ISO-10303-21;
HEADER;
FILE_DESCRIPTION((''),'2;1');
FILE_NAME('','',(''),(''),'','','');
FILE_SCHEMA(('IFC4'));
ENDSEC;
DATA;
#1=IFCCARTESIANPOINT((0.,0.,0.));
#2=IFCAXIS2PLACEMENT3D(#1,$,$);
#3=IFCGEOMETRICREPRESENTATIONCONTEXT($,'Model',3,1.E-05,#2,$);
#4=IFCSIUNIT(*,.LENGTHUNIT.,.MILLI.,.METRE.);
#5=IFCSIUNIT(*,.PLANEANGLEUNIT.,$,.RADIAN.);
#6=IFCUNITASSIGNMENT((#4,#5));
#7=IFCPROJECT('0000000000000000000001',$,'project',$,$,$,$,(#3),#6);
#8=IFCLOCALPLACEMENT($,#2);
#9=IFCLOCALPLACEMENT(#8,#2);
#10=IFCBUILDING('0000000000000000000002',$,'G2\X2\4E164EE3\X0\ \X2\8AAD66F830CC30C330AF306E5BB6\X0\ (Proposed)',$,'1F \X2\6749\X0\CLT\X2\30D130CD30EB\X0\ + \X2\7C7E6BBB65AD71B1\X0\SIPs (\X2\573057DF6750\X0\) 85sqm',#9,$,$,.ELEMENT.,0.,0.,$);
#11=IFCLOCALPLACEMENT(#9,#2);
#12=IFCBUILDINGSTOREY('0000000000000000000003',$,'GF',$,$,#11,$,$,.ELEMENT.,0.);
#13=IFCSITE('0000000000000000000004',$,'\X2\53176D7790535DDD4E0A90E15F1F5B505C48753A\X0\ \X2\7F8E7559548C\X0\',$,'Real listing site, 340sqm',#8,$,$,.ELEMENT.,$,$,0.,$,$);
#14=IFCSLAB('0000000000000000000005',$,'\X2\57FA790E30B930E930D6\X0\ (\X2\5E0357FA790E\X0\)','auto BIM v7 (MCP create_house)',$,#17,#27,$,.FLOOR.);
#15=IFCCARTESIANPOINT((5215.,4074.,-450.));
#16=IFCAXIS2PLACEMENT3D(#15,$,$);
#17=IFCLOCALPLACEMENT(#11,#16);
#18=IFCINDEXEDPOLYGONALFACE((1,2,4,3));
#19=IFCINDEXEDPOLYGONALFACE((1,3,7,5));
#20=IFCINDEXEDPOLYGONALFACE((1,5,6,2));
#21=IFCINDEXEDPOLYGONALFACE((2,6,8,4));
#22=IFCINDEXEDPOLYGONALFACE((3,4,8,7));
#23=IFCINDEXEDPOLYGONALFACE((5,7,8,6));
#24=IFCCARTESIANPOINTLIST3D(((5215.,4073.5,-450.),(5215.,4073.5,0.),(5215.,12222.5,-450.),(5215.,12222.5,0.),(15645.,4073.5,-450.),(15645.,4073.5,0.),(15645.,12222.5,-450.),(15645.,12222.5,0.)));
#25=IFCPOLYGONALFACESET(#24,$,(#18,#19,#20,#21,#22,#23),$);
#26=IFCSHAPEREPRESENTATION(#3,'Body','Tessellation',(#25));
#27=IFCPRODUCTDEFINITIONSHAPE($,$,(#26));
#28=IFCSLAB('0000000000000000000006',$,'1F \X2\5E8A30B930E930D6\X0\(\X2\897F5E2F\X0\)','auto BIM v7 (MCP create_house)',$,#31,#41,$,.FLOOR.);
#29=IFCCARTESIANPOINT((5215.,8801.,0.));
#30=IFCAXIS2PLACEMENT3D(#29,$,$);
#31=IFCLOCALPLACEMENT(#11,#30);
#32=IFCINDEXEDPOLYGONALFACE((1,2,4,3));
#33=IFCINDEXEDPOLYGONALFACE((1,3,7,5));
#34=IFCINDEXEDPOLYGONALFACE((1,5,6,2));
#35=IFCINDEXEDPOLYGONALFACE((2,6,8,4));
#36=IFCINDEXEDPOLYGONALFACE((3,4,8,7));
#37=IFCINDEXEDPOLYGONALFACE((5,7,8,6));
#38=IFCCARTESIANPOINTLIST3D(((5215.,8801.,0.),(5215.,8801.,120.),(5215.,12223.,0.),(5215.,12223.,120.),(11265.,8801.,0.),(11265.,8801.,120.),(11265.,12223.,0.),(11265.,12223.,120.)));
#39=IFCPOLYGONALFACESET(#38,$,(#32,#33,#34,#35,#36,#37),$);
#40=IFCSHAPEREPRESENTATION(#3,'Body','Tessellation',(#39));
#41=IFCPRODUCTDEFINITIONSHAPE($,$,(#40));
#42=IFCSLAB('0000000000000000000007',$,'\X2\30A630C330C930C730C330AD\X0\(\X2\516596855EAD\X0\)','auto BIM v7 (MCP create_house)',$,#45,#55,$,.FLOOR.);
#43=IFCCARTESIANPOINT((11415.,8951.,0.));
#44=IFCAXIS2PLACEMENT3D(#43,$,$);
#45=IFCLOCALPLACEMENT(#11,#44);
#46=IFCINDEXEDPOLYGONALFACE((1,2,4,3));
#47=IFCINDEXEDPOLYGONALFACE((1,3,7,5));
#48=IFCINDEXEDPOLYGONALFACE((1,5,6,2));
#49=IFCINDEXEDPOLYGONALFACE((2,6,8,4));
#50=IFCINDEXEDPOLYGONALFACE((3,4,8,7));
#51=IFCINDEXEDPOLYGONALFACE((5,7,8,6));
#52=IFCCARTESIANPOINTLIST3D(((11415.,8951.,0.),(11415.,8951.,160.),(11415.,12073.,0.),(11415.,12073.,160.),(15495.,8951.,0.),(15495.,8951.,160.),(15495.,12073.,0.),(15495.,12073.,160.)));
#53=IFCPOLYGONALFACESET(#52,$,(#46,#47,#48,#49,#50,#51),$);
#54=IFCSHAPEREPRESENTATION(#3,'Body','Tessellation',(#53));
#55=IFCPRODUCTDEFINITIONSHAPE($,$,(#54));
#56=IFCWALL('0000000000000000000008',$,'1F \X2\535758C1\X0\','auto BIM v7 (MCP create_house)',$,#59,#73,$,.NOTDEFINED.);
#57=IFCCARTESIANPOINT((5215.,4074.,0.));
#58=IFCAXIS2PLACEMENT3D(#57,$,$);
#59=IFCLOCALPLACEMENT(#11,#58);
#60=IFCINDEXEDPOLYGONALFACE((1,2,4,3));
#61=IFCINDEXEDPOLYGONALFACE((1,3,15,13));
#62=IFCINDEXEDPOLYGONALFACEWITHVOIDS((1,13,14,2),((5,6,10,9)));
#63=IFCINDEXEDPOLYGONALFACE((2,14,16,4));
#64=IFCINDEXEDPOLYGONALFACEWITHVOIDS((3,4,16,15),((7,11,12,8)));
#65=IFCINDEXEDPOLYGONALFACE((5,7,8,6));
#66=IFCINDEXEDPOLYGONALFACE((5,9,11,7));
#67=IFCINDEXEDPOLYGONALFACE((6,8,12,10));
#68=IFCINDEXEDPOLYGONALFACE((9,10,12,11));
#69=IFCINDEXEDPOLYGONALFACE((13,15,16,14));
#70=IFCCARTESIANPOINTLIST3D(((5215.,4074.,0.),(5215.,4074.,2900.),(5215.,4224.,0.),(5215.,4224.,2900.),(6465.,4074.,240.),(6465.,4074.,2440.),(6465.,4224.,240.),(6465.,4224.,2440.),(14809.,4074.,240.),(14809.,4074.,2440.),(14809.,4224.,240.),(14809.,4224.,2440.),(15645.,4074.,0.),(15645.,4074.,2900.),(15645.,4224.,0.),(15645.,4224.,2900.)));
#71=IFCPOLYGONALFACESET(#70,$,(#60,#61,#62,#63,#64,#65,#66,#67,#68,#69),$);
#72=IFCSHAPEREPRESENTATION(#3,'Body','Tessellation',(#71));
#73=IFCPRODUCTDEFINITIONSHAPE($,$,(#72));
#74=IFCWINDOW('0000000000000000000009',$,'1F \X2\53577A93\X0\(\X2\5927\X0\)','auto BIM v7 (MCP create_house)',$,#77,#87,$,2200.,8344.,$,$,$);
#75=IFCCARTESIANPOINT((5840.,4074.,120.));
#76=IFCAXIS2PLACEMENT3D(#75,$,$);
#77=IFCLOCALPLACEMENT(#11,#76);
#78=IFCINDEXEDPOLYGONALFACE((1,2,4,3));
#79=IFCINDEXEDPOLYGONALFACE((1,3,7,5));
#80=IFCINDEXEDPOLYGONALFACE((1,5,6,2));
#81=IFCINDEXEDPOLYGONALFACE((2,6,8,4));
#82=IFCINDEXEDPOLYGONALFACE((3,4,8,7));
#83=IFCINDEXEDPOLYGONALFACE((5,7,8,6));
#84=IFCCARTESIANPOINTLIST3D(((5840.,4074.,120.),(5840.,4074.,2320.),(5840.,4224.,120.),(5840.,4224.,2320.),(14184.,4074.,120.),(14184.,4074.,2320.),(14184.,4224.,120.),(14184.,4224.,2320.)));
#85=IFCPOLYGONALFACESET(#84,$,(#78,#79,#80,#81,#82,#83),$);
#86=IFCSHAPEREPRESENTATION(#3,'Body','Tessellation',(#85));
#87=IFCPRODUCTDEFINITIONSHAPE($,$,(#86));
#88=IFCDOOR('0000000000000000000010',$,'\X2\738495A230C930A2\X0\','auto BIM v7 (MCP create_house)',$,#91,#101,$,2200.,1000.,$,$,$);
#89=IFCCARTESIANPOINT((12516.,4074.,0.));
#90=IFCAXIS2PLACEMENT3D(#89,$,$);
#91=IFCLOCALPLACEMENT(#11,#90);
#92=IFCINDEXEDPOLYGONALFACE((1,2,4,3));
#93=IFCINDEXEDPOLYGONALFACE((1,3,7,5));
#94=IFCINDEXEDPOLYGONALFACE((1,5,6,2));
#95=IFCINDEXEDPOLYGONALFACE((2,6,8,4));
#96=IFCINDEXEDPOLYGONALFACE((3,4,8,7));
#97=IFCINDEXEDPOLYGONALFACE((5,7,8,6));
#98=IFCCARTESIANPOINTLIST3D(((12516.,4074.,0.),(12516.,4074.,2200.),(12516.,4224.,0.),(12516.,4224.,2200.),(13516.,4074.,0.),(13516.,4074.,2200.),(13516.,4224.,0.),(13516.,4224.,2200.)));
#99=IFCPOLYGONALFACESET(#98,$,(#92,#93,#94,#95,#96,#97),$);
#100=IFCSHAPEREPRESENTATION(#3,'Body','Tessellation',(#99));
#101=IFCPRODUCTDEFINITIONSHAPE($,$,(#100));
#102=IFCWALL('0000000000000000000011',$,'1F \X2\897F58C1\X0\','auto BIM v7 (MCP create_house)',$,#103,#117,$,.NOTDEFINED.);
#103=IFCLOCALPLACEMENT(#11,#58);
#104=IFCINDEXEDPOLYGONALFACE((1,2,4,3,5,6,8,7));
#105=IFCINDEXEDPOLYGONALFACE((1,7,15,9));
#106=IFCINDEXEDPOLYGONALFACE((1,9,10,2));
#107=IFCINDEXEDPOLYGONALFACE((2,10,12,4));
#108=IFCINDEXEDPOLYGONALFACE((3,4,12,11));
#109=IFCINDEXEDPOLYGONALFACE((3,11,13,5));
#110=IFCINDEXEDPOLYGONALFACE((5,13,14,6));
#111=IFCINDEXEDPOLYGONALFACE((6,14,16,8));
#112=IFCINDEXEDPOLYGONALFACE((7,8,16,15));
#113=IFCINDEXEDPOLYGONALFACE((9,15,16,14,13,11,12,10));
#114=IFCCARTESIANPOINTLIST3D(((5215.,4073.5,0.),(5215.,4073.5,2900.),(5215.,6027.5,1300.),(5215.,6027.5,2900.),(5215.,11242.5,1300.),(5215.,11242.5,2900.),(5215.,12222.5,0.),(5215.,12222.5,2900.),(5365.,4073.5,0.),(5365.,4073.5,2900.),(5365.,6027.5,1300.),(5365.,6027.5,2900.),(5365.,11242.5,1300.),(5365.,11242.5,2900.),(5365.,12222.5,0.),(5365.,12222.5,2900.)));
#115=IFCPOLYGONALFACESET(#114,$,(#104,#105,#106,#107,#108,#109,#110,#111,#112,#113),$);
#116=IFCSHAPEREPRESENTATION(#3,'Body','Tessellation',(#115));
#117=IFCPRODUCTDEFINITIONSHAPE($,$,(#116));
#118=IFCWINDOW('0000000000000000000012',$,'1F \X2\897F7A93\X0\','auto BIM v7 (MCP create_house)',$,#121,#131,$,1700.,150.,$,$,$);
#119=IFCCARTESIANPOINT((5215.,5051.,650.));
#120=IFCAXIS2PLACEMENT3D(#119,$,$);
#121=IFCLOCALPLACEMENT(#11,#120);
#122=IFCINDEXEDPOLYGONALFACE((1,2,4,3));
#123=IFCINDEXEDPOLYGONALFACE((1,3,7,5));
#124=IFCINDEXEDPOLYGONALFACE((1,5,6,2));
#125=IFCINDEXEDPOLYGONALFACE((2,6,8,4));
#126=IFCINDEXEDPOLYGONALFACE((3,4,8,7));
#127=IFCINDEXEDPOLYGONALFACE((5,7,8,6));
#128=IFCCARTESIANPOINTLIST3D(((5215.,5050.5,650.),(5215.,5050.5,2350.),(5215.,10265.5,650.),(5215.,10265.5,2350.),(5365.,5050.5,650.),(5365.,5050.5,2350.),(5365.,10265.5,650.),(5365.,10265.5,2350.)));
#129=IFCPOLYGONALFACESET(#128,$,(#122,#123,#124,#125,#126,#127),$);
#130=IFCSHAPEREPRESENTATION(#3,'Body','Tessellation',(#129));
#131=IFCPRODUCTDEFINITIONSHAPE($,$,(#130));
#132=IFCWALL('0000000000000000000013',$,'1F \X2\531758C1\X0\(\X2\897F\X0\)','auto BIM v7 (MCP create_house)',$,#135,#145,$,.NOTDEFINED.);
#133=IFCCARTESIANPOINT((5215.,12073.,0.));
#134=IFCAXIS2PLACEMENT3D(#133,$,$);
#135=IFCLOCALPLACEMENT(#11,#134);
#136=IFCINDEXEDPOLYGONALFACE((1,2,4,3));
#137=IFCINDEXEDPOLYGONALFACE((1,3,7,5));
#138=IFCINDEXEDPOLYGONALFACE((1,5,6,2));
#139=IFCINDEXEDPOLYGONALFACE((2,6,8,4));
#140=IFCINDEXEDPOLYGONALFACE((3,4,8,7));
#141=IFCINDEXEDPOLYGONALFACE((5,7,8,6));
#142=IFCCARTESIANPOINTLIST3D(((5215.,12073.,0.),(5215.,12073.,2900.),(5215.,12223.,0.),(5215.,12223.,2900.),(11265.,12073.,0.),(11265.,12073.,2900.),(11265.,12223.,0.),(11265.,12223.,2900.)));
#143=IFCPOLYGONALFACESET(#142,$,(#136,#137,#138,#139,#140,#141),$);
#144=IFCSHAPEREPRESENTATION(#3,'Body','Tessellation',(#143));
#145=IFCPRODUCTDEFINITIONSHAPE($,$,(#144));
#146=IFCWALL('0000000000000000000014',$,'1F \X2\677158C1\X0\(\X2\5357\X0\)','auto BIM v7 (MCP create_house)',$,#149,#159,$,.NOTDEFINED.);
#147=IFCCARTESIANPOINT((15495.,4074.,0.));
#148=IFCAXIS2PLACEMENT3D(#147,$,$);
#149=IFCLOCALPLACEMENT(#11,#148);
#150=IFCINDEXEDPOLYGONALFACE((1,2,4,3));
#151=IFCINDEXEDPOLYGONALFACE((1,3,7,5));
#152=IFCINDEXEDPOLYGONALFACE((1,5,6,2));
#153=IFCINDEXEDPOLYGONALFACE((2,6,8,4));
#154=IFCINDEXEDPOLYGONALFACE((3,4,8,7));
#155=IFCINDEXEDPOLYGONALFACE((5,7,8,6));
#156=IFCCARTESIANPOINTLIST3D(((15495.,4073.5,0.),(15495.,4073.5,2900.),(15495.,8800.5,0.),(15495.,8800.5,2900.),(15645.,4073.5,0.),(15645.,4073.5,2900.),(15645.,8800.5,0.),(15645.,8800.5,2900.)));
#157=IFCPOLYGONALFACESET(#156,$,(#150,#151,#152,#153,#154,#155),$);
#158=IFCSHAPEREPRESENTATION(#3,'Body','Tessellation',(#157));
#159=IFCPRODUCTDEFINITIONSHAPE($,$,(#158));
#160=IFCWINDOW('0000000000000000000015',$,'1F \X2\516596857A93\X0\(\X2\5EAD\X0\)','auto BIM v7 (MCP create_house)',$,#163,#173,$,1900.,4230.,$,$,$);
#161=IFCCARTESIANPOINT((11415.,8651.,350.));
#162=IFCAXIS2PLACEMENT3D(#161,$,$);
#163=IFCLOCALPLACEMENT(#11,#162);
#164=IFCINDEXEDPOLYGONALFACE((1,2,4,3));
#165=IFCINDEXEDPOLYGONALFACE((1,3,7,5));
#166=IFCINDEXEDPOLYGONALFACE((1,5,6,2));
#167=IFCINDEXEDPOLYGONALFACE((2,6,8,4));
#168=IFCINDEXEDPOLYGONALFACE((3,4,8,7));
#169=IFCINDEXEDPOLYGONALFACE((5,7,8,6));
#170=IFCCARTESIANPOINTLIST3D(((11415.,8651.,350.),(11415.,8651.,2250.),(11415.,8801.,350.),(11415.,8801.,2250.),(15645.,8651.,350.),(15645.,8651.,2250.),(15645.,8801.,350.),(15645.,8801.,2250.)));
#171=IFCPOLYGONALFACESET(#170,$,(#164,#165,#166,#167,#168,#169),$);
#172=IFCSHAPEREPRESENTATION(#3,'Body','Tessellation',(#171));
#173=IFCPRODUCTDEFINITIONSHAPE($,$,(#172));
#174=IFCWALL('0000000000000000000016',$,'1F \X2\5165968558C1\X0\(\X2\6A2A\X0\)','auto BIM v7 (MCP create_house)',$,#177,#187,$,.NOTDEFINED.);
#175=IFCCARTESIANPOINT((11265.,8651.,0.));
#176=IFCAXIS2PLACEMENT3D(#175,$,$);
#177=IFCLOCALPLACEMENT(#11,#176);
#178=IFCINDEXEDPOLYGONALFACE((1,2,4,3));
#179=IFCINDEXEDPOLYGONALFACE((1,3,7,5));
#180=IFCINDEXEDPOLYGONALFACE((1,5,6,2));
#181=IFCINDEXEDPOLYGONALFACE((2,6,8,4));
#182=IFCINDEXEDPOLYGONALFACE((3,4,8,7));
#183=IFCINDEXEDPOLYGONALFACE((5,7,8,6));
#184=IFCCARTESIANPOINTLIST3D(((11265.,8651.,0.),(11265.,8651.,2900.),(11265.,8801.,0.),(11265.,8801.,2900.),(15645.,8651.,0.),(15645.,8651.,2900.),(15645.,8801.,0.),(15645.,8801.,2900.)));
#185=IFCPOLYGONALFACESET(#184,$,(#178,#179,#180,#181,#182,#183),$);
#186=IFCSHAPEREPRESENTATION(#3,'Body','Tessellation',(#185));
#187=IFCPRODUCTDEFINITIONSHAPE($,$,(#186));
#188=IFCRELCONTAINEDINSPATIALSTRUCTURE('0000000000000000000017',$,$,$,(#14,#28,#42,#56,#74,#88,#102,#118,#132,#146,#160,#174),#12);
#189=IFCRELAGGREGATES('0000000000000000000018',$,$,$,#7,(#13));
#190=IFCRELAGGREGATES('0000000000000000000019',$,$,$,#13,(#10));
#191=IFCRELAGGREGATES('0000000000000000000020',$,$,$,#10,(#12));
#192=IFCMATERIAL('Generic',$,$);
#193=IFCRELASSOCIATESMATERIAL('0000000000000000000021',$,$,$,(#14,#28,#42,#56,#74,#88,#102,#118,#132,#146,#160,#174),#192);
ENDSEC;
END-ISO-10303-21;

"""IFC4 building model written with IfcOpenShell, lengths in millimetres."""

from ifc_helpers import new_model, si_unit, frame, frame_2d, origin, place, context, project, spatial, rectangle, extrude, material, element, fill, save


model = new_model("IFC4")

# Units and contexts
model_context = context("Model", 3, precision=1e-05, world=origin())
ifc_project = project(units=[si_unit("LENGTHUNIT", "METRE", prefix="MILLI"), si_unit("PLANEANGLEUNIT", "RADIAN")], contexts=[model_context])

# Site, building, storey
site_placement = place(None, origin())
site = spatial("IfcSite", under=ifc_project, at=site_placement, Name="北海道川上郡弟子屈町 美留和", ObjectType="Real listing site, 340sqm", CompositionType="ELEMENT", RefElevation=0.0)
building_placement = place(site_placement, origin())
building = spatial("IfcBuilding", under=site, at=building_placement, Name="G2世代 読書ヌックの家 (Proposed)", ObjectType="1F 杉CLTパネル + 籾殻断熱SIPs (地域材) 85sqm", CompositionType="ELEMENT", ElevationOfRefHeight=0.0, ElevationOfTerrain=0.0)
storey_placement = place(building_placement, origin())
storey = spatial("IfcBuildingStorey", under=building, at=storey_placement, Name="GF", CompositionType="ELEMENT", Elevation=0.0)

# Slabs
ifc_material = material(Name="Generic")
slab_1_placement = place(storey_placement, frame((5215.0, 4074.0, -450.0)))
element("IfcSlab", 1, at=slab_1_placement, inside=storey, material=ifc_material, Name="基礎スラブ (布基礎)", Description="auto BIM v7 (MCP create_house)", PredefinedType="FLOOR", context=model_context, shape_type="SweptSolid", body=[
    extrude(rectangle(XDim=10430.0, YDim=8149.0, at=frame_2d((5215.0, 4074.0))), frame((5215.0, 4074.0, -450.0)), (0.0, 0.0, 1.0), 450.0),
])
slab_2_placement = place(storey_placement, frame((5215.0, 8801.0, 0.0)))
element("IfcSlab", 2, at=slab_2_placement, inside=storey, material=ifc_material, Name="1F 床スラブ(西帯)", Description="auto BIM v7 (MCP create_house)", PredefinedType="FLOOR", context=model_context, shape_type="SweptSolid", body=[
    extrude(rectangle(XDim=6050.0, YDim=3422.0, at=frame_2d((3025.0, 1711.0))), frame((5215.0, 8801.0, 0.0)), (0.0, 0.0, 1.0), 120.0),
])
slab_3_placement = place(storey_placement, frame((11415.0, 8951.0, 0.0)))
element("IfcSlab", 3, at=slab_3_placement, inside=storey, material=ifc_material, Name="ウッドデッキ(入隅庭)", Description="auto BIM v7 (MCP create_house)", PredefinedType="FLOOR", context=model_context, shape_type="SweptSolid", body=[
    extrude(rectangle(XDim=4080.0, YDim=3122.0, at=frame_2d((2040.0, 1561.0))), frame((11415.0, 8951.0, 0.0)), (0.0, 0.0, 1.0), 160.0),
])

# Wall, openings, window, door
wall_1_placement = place(storey_placement, frame((5215.0, 4074.0, 0.0)))
wall_1 = element("IfcWall", 4, at=wall_1_placement, inside=storey, material=ifc_material, Name="1F 南壁", Description="auto BIM v7 (MCP create_house)", PredefinedType="NOTDEFINED", context=model_context, shape_type="SweptSolid", body=[
    extrude(rectangle(XDim=10430.0, YDim=150.0, at=frame_2d((5215.0, 75.0))), frame((5215.0, 4074.0, 0.0)), (0.0, 0.0, 1.0), 2900.0),
])
opening_1_placement = place(storey_placement, frame((5840.0, 4074.0, 120.0)))
opening_1 = element("IfcOpeningElement", 5, at=opening_1_placement, cuts=wall_1, PredefinedType="NOTDEFINED", context=model_context, shape_type="SweptSolid", body=[
    extrude(rectangle(XDim=8344.0, YDim=150.0, at=frame_2d((4172.0, 75.0))), frame((5840.0, 4074.0, 120.0)), (0.0, 0.0, 1.0), 2200.0),
])
opening_2_placement = place(storey_placement, frame((12516.0, 4074.0, 0.0)))
opening_2 = element("IfcOpeningElement", 6, at=opening_2_placement, cuts=wall_1, PredefinedType="NOTDEFINED", context=model_context, shape_type="SweptSolid", body=[
    extrude(rectangle(XDim=1000.0, YDim=150.0, at=frame_2d((500.0, 75.0))), frame((12516.0, 4074.0, 0.0)), (0.0, 0.0, 1.0), 2200.0),
])
window_1_placement = place(storey_placement, frame((5840.0, 4074.0, 120.0)))
window_1 = element("IfcWindow", 7, at=window_1_placement, inside=storey, material=ifc_material, Name="1F 南窓(大)", Description="auto BIM v7 (MCP create_house)", OverallHeight=2200.0, OverallWidth=8344.0, context=model_context, shape_type="SweptSolid", body=[
    extrude(rectangle(XDim=8344.0, YDim=150.0, at=frame_2d((4172.0, 75.0))), frame((5840.0, 4074.0, 120.0)), (0.0, 0.0, 1.0), 2200.0),
])
fill(opening_1, window_1)
door_placement = place(storey_placement, frame((12516.0, 4074.0, 0.0)))
door = element("IfcDoor", 8, at=door_placement, inside=storey, material=ifc_material, Name="玄関ドア", Description="auto BIM v7 (MCP create_house)", OverallHeight=2200.0, OverallWidth=1000.0, context=model_context, shape_type="SweptSolid", body=[
    extrude(rectangle(XDim=1000.0, YDim=150.0, at=frame_2d((500.0, 75.0))), frame((12516.0, 4074.0, 0.0)), (0.0, 0.0, 1.0), 2200.0),
])
fill(opening_2, door)

# Wall, opening, window
wall_2_placement = place(storey_placement, frame((5215.0, 4074.0, 0.0)))
wall_2 = element("IfcWall", 9, at=wall_2_placement, inside=storey, material=ifc_material, Name="1F 西壁", Description="auto BIM v7 (MCP create_house)", PredefinedType="NOTDEFINED", context=model_context, shape_type="SweptSolid", body=[
    extrude(rectangle(XDim=150.0, YDim=8149.0, at=frame_2d((75.0, 4074.0))), frame((5215.0, 4074.0, 0.0)), (0.0, 0.0, 1.0), 2900.0),
])
opening_3_placement = place(storey_placement, frame((5215.0, 5051.0, 650.0)))
opening_3 = element("IfcOpeningElement", 10, at=opening_3_placement, cuts=wall_2, PredefinedType="NOTDEFINED", context=model_context, shape_type="SweptSolid", body=[
    extrude(rectangle(XDim=150.0, YDim=5215.0, at=frame_2d((75.0, 2607.0))), frame((5215.0, 5051.0, 650.0)), (0.0, 0.0, 1.0), 1700.0),
])
window_2_placement = place(storey_placement, frame((5215.0, 5051.0, 650.0)))
window_2 = element("IfcWindow", 11, at=window_2_placement, inside=storey, material=ifc_material, Name="1F 西窓", Description="auto BIM v7 (MCP create_house)", OverallHeight=1700.0, OverallWidth=150.0, context=model_context, shape_type="SweptSolid", body=[
    extrude(rectangle(XDim=150.0, YDim=5215.0, at=frame_2d((75.0, 2607.0))), frame((5215.0, 5051.0, 650.0)), (0.0, 0.0, 1.0), 1700.0),
])
fill(opening_3, window_2)

# Wall
wall_3_placement = place(storey_placement, frame((5215.0, 12073.0, 0.0)))
element("IfcWall", 12, at=wall_3_placement, inside=storey, material=ifc_material, Name="1F 北壁(西)", Description="auto BIM v7 (MCP create_house)", PredefinedType="NOTDEFINED", context=model_context, shape_type="SweptSolid", body=[
    extrude(rectangle(XDim=6050.0, YDim=150.0, at=frame_2d((3025.0, 75.0))), frame((5215.0, 12073.0, 0.0)), (0.0, 0.0, 1.0), 2900.0),
])

# Wall, opening, window
wall_4_placement = place(storey_placement, frame((15495.0, 4074.0, 0.0)))
wall_4 = element("IfcWall", 13, at=wall_4_placement, inside=storey, material=ifc_material, Name="1F 東壁(南)", Description="auto BIM v7 (MCP create_house)", PredefinedType="NOTDEFINED", context=model_context, shape_type="SweptSolid", body=[
    extrude(rectangle(XDim=150.0, YDim=4727.0, at=frame_2d((75.0, 2363.0))), frame((15495.0, 4074.0, 0.0)), (0.0, 0.0, 1.0), 2900.0),
])
opening_4_placement = place(storey_placement, frame((11415.0, 8651.0, 350.0)))
opening_4 = element("IfcOpeningElement", 14, at=opening_4_placement, cuts=wall_4, PredefinedType="NOTDEFINED", context=model_context, shape_type="SweptSolid", body=[
    extrude(rectangle(XDim=4230.0, YDim=150.0, at=frame_2d((2115.0, 75.0))), frame((11415.0, 8651.0, 350.0)), (0.0, 0.0, 1.0), 1900.0),
])
window_3_placement = place(storey_placement, frame((11415.0, 8651.0, 350.0)))
window_3 = element("IfcWindow", 15, at=window_3_placement, inside=storey, material=ifc_material, Name="1F 入隅窓(庭)", Description="auto BIM v7 (MCP create_house)", OverallHeight=1900.0, OverallWidth=4230.0, context=model_context, shape_type="SweptSolid", body=[
    extrude(rectangle(XDim=4230.0, YDim=150.0, at=frame_2d((2115.0, 75.0))), frame((11415.0, 8651.0, 350.0)), (0.0, 0.0, 1.0), 1900.0),
])
fill(opening_4, window_3)

# Wall
wall_5_placement = place(storey_placement, frame((11265.0, 8651.0, 0.0)))
element("IfcWall", 16, at=wall_5_placement, inside=storey, material=ifc_material, Name="1F 入隅壁(横)", Description="auto BIM v7 (MCP create_house)", PredefinedType="NOTDEFINED", context=model_context, shape_type="SweptSolid", body=[
    extrude(rectangle(XDim=4380.0, YDim=150.0, at=frame_2d((2190.0, 75.0))), frame((11265.0, 8651.0, 0.0)), (0.0, 0.0, 1.0), 2900.0),
])

save(model, "model.ifc")
